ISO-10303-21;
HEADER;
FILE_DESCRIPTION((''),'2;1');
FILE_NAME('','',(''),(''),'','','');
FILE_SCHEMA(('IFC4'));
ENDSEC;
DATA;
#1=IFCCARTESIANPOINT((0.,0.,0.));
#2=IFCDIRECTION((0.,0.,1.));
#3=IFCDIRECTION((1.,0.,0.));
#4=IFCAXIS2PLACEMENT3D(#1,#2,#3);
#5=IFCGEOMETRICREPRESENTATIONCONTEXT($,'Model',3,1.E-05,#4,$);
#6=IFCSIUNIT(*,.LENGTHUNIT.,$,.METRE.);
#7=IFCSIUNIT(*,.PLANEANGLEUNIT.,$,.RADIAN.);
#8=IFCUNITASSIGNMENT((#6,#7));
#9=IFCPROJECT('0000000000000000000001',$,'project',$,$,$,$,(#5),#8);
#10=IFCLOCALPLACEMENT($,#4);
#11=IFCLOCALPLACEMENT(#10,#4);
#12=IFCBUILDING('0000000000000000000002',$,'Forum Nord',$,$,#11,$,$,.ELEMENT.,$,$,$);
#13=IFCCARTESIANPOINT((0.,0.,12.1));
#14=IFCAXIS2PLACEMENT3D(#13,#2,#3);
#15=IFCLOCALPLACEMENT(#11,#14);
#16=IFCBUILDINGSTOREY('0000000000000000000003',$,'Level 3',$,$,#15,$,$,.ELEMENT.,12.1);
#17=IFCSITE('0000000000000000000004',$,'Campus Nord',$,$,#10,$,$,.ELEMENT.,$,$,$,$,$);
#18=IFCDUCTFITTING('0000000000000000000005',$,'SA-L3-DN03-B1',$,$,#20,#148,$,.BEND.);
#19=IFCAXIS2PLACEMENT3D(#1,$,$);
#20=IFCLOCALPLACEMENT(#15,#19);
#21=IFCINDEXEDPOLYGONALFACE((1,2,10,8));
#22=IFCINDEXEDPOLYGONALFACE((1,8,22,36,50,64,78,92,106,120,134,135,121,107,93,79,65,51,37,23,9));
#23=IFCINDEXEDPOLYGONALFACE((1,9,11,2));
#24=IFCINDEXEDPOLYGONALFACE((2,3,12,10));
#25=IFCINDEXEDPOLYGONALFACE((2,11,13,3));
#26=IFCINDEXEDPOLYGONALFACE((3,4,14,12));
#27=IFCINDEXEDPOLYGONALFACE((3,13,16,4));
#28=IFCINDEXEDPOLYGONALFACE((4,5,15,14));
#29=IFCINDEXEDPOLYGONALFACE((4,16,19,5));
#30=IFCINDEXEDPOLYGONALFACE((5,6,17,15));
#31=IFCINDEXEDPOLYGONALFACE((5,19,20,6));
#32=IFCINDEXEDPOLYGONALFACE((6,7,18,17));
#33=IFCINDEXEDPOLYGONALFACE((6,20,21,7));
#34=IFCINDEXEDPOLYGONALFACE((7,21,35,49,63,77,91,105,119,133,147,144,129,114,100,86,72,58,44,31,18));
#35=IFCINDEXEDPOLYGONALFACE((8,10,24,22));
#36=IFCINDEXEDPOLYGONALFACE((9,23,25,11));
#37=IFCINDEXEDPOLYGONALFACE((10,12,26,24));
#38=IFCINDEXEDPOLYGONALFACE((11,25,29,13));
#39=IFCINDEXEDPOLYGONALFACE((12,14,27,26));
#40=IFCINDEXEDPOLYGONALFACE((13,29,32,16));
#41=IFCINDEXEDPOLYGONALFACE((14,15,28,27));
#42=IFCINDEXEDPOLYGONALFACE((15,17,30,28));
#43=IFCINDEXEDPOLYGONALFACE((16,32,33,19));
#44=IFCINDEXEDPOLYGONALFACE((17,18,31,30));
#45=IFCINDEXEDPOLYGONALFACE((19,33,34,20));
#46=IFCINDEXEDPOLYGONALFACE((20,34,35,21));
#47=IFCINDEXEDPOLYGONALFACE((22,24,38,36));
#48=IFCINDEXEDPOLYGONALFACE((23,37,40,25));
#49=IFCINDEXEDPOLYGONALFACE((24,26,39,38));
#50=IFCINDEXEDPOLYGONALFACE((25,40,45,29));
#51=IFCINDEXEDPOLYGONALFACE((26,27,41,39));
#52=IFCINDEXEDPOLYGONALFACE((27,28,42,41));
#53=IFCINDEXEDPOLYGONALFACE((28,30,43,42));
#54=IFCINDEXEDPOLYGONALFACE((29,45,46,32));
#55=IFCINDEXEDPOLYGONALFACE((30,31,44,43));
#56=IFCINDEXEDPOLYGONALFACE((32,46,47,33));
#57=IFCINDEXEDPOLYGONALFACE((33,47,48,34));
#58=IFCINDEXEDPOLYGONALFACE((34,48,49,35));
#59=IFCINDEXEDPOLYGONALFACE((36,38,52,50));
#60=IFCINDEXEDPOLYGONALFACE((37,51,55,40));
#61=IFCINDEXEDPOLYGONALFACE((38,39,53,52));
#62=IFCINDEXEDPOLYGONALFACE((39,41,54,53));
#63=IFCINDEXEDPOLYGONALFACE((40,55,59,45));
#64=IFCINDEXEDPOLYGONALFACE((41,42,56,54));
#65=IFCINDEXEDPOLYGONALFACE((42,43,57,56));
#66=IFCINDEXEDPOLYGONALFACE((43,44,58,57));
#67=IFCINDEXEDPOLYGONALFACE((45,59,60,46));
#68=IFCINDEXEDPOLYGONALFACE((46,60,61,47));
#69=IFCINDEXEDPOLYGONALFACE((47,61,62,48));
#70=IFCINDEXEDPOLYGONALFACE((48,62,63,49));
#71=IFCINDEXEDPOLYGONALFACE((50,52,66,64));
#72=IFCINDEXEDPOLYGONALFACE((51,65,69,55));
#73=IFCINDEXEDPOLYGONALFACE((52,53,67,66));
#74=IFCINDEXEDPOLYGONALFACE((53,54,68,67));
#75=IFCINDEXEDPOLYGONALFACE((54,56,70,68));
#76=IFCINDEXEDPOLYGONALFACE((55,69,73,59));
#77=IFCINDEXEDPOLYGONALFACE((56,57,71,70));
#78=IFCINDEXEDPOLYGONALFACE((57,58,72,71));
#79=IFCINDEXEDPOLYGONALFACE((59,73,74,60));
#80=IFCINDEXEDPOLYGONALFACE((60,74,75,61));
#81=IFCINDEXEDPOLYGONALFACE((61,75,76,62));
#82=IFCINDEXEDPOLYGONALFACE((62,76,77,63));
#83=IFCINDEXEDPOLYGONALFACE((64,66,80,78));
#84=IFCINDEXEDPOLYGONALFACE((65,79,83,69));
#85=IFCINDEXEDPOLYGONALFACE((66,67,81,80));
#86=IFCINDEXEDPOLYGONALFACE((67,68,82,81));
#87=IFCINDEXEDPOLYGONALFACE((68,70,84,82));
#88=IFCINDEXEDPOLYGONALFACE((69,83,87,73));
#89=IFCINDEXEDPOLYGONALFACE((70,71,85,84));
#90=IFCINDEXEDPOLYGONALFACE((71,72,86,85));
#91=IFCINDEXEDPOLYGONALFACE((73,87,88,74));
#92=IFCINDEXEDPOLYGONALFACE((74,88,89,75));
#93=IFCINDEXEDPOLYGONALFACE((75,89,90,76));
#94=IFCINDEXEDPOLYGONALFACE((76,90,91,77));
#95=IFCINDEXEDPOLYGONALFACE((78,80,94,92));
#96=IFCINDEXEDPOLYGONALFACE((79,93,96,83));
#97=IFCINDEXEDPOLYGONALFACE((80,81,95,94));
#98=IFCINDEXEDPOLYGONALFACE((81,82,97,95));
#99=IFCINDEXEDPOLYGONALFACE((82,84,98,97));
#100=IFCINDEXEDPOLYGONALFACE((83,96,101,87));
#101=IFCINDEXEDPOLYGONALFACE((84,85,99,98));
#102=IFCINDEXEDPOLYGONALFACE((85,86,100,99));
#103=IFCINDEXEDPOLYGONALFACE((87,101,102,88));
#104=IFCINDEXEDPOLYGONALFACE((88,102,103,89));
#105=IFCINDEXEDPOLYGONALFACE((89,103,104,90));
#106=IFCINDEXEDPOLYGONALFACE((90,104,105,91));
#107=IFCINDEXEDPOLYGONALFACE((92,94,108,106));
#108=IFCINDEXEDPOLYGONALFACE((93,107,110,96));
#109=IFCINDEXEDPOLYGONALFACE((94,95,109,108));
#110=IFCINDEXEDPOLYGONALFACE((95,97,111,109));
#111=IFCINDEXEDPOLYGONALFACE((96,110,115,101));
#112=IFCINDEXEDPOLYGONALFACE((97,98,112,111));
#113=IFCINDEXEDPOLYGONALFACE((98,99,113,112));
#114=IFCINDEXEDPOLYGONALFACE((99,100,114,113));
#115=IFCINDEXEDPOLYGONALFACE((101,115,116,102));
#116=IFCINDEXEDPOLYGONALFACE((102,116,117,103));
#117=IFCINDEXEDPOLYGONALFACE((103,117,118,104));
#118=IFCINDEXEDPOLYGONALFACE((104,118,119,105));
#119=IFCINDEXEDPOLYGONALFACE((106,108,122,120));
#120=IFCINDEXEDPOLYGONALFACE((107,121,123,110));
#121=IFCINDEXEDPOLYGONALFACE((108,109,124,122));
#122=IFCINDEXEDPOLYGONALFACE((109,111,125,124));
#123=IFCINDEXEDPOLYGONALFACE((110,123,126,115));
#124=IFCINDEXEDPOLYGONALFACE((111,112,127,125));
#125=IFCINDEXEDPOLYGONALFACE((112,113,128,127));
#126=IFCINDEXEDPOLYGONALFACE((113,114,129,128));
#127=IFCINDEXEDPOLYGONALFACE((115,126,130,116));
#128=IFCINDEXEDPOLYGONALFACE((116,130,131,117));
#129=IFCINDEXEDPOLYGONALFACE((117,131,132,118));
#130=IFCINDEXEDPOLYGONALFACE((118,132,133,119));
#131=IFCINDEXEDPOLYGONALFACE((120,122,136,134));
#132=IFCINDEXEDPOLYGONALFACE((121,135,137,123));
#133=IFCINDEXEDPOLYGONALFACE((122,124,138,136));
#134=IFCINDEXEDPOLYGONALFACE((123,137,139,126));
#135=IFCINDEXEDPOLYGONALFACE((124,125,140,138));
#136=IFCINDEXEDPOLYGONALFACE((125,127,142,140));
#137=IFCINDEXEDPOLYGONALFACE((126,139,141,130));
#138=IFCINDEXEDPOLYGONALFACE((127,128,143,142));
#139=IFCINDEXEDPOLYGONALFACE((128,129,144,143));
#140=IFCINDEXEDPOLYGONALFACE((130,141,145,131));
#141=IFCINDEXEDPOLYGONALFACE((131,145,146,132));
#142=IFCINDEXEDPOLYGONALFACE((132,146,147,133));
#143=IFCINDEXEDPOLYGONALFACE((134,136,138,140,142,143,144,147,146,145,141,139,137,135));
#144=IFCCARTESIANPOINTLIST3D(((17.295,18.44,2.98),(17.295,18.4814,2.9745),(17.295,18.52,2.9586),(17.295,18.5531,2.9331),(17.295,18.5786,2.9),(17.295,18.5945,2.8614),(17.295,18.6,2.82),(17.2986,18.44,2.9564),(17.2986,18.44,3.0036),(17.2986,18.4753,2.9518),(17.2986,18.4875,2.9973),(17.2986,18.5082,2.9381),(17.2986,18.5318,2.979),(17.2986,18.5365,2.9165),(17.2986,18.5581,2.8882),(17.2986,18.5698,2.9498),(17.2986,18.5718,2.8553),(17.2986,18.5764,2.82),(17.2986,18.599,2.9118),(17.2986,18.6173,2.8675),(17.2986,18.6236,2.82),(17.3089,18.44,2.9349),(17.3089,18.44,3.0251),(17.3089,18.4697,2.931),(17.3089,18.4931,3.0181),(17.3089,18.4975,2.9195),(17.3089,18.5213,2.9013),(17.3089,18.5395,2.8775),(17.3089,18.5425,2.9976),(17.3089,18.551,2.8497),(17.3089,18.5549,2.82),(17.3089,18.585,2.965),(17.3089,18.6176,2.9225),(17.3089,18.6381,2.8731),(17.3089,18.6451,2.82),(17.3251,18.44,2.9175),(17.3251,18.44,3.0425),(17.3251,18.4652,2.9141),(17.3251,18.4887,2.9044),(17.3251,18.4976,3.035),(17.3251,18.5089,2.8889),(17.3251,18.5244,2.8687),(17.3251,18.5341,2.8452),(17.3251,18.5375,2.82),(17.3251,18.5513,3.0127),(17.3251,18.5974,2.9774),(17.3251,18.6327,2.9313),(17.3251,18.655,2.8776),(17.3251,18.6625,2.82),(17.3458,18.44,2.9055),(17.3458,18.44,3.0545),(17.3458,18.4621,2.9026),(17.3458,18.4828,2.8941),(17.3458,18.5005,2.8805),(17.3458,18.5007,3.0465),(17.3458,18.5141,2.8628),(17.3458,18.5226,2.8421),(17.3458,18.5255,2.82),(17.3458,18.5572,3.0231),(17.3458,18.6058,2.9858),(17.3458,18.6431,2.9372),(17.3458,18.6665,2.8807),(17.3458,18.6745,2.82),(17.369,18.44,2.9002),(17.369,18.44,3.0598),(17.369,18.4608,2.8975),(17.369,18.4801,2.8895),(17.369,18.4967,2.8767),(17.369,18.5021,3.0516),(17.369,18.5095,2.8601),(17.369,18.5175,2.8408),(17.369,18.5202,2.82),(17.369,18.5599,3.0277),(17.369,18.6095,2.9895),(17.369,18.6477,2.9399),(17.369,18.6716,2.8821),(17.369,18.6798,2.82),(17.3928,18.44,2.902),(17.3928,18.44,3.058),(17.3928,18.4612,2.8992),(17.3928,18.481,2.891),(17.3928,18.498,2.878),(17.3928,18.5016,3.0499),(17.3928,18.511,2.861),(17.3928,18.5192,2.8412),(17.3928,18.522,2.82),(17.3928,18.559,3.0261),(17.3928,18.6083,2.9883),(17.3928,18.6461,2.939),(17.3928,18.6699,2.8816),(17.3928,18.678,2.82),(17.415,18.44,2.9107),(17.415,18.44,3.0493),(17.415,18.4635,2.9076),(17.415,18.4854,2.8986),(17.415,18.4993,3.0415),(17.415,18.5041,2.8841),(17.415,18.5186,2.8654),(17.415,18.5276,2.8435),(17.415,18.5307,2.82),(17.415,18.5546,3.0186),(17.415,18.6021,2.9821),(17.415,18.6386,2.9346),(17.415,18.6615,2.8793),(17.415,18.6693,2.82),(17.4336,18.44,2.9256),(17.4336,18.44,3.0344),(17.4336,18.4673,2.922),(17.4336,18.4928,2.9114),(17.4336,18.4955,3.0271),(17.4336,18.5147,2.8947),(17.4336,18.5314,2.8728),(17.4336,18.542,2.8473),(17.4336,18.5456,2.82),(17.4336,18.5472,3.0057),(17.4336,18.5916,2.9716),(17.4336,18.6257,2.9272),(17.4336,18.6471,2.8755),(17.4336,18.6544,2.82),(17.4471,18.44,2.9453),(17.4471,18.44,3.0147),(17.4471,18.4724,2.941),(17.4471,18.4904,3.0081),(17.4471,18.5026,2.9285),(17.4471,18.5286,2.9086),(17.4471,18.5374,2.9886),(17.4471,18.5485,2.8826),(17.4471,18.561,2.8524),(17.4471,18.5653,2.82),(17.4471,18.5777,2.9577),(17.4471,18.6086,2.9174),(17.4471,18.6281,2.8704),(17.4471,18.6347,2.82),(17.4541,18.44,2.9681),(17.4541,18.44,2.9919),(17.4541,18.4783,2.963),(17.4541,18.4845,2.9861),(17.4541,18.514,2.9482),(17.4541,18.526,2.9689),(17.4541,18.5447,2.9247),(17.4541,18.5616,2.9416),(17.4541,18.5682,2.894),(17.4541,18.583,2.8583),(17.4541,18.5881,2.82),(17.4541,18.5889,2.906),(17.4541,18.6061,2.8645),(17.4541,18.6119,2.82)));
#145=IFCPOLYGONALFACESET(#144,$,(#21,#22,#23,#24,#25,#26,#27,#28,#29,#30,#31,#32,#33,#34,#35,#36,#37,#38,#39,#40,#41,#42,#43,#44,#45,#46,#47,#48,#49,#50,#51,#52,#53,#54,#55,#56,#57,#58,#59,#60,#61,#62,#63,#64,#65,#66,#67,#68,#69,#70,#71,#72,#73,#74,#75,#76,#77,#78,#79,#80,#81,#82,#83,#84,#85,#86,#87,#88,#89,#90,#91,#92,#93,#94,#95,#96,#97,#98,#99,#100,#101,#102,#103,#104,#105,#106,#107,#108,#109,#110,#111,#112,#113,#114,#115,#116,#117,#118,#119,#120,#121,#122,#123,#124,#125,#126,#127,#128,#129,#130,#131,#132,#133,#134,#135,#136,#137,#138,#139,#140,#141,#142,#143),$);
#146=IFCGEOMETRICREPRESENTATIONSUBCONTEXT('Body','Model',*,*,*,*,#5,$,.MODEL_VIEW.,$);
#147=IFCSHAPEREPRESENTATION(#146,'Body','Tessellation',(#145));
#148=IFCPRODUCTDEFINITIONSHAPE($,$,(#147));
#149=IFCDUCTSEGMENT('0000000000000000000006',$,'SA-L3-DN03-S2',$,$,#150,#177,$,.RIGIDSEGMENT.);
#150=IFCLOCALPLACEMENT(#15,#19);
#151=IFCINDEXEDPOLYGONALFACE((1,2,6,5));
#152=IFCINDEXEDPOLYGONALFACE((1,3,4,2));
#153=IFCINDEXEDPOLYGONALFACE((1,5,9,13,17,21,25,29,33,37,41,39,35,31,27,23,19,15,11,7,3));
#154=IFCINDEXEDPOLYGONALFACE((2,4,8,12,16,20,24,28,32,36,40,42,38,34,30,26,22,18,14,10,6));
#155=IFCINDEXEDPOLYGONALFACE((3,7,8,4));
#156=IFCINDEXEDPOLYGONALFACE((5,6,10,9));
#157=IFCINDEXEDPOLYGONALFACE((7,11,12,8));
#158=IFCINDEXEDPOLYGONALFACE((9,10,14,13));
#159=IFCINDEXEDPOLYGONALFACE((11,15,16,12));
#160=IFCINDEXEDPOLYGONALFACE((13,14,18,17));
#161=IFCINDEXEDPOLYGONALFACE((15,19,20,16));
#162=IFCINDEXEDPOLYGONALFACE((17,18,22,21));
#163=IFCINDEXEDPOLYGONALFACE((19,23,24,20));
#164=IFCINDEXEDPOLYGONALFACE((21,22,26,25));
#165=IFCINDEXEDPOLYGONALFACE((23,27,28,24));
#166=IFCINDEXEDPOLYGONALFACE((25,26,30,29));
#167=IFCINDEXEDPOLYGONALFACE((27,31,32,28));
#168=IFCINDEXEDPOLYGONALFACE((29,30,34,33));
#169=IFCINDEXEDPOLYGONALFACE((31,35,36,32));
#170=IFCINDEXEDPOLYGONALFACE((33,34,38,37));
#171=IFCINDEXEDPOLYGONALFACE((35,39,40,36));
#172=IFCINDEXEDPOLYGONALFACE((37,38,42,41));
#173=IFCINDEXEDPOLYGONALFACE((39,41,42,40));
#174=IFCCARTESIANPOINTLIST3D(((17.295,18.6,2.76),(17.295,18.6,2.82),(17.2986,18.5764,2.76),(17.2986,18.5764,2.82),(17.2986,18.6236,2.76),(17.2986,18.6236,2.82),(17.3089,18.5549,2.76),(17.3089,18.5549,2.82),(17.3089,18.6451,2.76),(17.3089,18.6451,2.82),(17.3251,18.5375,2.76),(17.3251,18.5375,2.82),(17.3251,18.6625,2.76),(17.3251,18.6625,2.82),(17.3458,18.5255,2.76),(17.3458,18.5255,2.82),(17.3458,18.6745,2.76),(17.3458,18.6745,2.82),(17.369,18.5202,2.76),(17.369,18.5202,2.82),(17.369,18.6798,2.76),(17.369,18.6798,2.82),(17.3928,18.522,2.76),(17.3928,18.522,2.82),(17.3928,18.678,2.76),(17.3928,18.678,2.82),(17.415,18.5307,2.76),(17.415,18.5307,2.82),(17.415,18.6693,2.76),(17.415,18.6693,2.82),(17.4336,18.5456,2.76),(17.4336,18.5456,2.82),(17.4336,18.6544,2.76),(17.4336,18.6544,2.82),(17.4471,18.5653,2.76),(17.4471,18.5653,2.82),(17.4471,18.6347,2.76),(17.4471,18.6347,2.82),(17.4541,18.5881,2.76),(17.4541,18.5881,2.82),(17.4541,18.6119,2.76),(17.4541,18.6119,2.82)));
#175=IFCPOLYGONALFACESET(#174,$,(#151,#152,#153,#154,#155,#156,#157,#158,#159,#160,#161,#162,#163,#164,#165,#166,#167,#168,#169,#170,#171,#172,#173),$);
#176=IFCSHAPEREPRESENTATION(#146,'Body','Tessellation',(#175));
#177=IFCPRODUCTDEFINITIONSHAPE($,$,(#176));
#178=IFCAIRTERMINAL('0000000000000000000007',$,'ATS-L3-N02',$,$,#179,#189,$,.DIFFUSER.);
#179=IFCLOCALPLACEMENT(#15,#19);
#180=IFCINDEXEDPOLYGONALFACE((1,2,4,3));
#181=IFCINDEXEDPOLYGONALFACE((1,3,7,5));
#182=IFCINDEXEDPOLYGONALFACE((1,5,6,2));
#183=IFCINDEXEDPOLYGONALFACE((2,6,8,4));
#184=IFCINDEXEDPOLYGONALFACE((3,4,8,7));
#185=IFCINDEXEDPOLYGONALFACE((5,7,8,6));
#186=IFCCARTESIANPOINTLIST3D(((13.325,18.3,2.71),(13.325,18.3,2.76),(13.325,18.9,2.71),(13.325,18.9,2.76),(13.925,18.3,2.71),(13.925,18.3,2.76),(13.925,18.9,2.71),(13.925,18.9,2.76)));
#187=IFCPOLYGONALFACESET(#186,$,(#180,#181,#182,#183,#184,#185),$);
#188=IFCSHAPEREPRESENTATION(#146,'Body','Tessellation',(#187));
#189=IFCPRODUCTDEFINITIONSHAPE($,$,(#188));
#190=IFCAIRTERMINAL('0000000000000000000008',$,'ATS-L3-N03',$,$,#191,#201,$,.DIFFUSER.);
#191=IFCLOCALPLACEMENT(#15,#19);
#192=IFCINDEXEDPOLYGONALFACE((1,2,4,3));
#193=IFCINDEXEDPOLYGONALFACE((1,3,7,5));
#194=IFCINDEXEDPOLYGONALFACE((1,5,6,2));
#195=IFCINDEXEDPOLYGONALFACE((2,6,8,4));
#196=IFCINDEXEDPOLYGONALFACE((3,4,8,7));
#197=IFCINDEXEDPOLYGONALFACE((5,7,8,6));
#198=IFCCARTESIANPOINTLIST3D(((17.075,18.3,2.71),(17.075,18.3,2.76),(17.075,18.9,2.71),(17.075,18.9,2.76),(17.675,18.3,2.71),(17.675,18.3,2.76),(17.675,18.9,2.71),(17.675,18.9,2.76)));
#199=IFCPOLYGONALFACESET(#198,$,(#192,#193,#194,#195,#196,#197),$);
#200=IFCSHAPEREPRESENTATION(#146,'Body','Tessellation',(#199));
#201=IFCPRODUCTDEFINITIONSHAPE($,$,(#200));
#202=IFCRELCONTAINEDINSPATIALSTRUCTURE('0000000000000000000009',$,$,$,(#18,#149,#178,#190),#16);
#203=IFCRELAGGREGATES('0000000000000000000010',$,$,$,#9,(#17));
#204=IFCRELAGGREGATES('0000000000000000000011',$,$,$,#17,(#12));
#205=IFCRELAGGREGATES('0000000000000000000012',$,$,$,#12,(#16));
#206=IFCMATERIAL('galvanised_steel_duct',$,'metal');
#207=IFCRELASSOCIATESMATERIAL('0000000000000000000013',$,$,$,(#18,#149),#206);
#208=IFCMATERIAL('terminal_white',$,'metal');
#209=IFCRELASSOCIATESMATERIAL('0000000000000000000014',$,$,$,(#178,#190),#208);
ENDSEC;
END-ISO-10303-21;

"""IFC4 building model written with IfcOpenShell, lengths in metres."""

from ifc_helpers import new_model, entity, si_unit, frame, origin_with_axes, origin_2d_with_axis, place, context, subcontext, project, spatial, rectangle, circle, extrude, material, element, save


model = new_model("IFC4")

# Units and contexts
model_context = context("Model", 3, precision=1e-05, world=origin_with_axes())
body_context = subcontext(model_context, "Body", "Model", "MODEL_VIEW")
ifc_project = project(units=[si_unit("LENGTHUNIT", "METRE"), si_unit("PLANEANGLEUNIT", "RADIAN")], contexts=[model_context])

# Site, building, storey
site_placement = place(None, origin_with_axes())
site = spatial("IfcSite", under=ifc_project, at=site_placement, Name="Campus Nord", CompositionType="ELEMENT")
building_placement = place(site_placement, origin_with_axes())
building = spatial("IfcBuilding", under=site, at=building_placement, Name="Forum Nord", CompositionType="ELEMENT")
storey_placement = place(building_placement, frame((0.0, 0.0, 12.1), z_axis=(0.0, 0.0, 1.0), x_axis=(1.0, 0.0, 0.0)))
storey = spatial("IfcBuildingStorey", under=building, at=storey_placement, Name="Level 3", CompositionType="ELEMENT", Elevation=12.1)

# Shared definitions
ifc_material_1 = material(Name="galvanised_steel_duct", Category="metal")

# Duct fitting
duct_fitting_1_placement = place(storey_placement, frame((17.375, 18.44, 2.98), z_axis=(0.0, 1.0, 0.0), x_axis=(-1.0, 0.0, 0.0)))
ifc_direction_1 = entity("IfcDirection", [1.0, 0.0, 0.0])
element("IfcDuctFitting", 1, at=duct_fitting_1_placement, inside=storey, material=ifc_material_1, Name="SA-L3-DN03-B1", PredefinedType="BEND", context=body_context, shape_type="SweptSolid", body=[
    entity("IfcRevolvedAreaSolid", entity("IfcCircleProfileDef", "AREA", None, entity("IfcAxis2Placement2D", entity("IfcCartesianPoint", [0.0, 0.0]), entity("IfcDirection", [1.0, 0.0])), 0.08), entity("IfcAxis2Placement3D", entity("IfcCartesianPoint", [0.0, 0.0, 0.0]), entity("IfcDirection", [0.0, 0.0, 1.0]), ifc_direction_1), entity("IfcAxis1Placement", entity("IfcCartesianPoint", [0.0, -0.16, 0.0]), ifc_direction_1), 1.5708),
])

# Duct segment
duct_segment_1_placement = place(storey_placement, frame((17.375, 18.6, 2.82), z_axis=(0.0, 0.0, -1.0), x_axis=(-1.0, 0.0, 0.0)))
element("IfcDuctSegment", 2, at=duct_segment_1_placement, inside=storey, material=ifc_material_1, Name="SA-L3-DN03-S2", PredefinedType="RIGIDSEGMENT", context=body_context, shape_type="SweptSolid", body=[
    extrude(circle(Radius=0.08, at=origin_2d_with_axis()), origin_with_axes(), (0.0, 0.0, 1.0), 0.06),
])

# Air terminals
ifc_material_2 = material(Name="terminal_white", Category="metal")
for number, where, z_axis, x_axis, name in (
    (3, (13.625, 18.6, 2.71), (0.0, 0.0, 1.0), (1.0, 0.0, 0.0), "ATS-L3-N02"),
    (4, (17.375, 18.6, 2.71), (0.0, 0.0, 1.0), (1.0, 0.0, 0.0), "ATS-L3-N03"),
):
    element("IfcAirTerminal", number, at=place(storey_placement, frame(where, z_axis=z_axis, x_axis=x_axis)), inside=storey, material=ifc_material_2, Name=name, PredefinedType="DIFFUSER", context=body_context, shape_type="SweptSolid", body=[
        extrude(rectangle(XDim=0.6, YDim=0.6, at=origin_2d_with_axis()), origin_with_axes(), (0.0, 0.0, 1.0), 0.05),
    ])

save(model, "model.ifc")
